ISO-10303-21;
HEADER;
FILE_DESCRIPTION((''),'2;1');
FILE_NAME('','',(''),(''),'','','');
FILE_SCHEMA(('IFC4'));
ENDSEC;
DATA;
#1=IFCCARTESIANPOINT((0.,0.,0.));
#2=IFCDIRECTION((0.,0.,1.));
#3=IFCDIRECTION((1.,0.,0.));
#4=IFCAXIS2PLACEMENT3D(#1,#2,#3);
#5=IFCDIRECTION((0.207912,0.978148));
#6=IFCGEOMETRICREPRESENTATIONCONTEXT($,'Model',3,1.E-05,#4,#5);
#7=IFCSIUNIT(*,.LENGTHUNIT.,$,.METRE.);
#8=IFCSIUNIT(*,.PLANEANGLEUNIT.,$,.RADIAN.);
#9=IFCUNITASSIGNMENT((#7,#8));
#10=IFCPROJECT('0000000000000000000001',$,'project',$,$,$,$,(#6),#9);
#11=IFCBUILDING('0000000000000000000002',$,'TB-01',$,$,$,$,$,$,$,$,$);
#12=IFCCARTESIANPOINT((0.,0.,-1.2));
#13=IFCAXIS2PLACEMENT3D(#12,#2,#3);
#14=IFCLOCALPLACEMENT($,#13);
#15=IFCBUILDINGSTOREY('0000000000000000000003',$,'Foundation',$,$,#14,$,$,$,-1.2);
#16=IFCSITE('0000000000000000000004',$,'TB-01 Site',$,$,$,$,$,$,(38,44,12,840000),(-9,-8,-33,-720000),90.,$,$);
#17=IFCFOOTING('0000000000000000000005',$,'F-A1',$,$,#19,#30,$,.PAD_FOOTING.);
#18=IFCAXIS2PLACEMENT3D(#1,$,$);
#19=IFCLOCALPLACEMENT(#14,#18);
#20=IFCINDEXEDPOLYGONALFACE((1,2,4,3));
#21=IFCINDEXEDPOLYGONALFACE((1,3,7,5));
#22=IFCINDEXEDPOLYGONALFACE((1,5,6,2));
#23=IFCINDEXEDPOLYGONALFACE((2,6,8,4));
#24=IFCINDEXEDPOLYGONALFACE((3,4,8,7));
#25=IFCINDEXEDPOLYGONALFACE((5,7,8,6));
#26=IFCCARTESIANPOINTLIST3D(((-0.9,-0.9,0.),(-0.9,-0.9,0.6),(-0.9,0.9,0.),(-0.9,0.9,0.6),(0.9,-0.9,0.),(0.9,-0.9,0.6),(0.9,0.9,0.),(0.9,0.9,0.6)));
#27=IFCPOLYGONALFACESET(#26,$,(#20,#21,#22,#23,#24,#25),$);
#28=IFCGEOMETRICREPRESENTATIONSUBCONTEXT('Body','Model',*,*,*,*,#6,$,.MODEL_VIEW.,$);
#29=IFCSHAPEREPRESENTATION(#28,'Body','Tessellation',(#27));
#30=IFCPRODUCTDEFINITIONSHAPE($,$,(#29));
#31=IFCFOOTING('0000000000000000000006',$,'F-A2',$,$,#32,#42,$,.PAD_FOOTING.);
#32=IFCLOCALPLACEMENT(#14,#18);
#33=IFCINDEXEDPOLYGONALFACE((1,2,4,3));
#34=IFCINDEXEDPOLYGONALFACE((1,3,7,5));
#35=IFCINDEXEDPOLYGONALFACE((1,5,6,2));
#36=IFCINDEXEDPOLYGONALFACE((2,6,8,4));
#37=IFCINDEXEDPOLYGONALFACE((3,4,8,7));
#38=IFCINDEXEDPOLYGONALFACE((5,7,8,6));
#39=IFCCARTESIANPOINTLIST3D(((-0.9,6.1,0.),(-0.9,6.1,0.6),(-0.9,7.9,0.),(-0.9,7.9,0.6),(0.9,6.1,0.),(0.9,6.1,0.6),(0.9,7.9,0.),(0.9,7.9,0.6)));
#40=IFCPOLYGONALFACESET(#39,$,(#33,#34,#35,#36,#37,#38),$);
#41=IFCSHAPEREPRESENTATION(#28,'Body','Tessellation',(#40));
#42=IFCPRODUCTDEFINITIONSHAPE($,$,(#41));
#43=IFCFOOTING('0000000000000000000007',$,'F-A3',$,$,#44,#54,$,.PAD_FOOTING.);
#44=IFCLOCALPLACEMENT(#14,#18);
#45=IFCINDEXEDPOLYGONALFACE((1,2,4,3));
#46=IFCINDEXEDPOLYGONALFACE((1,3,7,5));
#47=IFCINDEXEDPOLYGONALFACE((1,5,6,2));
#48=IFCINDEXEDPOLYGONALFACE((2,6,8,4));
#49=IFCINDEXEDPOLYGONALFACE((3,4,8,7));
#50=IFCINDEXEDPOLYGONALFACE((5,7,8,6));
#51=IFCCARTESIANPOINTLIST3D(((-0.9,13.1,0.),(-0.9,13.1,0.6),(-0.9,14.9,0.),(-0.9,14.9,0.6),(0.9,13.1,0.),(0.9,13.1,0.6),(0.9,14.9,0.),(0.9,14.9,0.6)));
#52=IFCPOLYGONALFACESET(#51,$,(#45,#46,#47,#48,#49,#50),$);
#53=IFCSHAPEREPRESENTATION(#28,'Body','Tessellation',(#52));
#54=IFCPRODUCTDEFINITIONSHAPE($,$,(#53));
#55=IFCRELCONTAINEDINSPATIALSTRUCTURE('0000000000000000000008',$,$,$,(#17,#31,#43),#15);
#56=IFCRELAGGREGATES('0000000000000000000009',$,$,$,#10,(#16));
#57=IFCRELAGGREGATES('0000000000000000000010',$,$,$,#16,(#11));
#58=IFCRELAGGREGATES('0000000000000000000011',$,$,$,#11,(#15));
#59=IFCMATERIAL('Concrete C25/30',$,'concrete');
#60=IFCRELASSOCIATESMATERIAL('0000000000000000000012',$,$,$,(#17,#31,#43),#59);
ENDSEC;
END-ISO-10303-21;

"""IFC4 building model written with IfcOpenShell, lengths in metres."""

from ifc_helpers import new_model, si_unit, direction, frame, origin_with_axes, place, context, subcontext, project, spatial, rectangle, extrude, material, element, save


model = new_model("IFC4")

# Units and contexts
model_context = context("Model", 3, precision=1e-05, world=origin_with_axes(), true_north=direction((0.207912, 0.978148)))
body_context = subcontext(model_context, "Body", "Model", "MODEL_VIEW")
ifc_project = project(units=[si_unit("LENGTHUNIT", "METRE"), si_unit("PLANEANGLEUNIT", "RADIAN")], contexts=[model_context])

# Site, building, storey
site = spatial("IfcSite", under=ifc_project, Name="TB-01 Site", RefLatitude=(38, 44, 12, 840000), RefLongitude=(-9, -8, -33, -720000), RefElevation=90.0)
building = spatial("IfcBuilding", under=site, Name="TB-01")
storey_placement = place(None, frame((0.0, 0.0, -1.2), z_axis=(0.0, 0.0, 1.0), x_axis=(1.0, 0.0, 0.0)))
storey = spatial("IfcBuildingStorey", under=building, at=storey_placement, Name="Foundation", Elevation=-1.2)

# Footings
ifc_material_1 = material(Name="Concrete C25/30", Category="concrete")
footing_placement = place(storey_placement, origin_with_axes())
element("IfcFooting", 1, at=footing_placement, inside=storey, material=ifc_material_1, Name="F-A1", PredefinedType="PAD_FOOTING", context=body_context, shape_type="SweptSolid", body=[
    extrude(rectangle(XDim=1.8, YDim=1.8), origin_with_axes(), (0.0, 0.0, 1.0), 0.6),
])
for number, where, z_axis, x_axis, name in (
    (2, (0.0, 7.0, 0.0), (0.0, 0.0, 1.0), (1.0, 0.0, 0.0), "F-A2"),
    (3, (0.0, 14.0, 0.0), (0.0, 0.0, 1.0), (1.0, 0.0, 0.0), "F-A3"),
):
    element("IfcFooting", number, at=place(storey_placement, frame(where, z_axis=z_axis, x_axis=x_axis)), inside=storey, material=ifc_material_1, Name=name, PredefinedType="PAD_FOOTING", context=body_context, shape_type="SweptSolid", body=[
        extrude(rectangle(XDim=1.8, YDim=1.8), origin_with_axes(), (0.0, 0.0, 1.0), 0.6),
    ])

save(model, "model.ifc")
